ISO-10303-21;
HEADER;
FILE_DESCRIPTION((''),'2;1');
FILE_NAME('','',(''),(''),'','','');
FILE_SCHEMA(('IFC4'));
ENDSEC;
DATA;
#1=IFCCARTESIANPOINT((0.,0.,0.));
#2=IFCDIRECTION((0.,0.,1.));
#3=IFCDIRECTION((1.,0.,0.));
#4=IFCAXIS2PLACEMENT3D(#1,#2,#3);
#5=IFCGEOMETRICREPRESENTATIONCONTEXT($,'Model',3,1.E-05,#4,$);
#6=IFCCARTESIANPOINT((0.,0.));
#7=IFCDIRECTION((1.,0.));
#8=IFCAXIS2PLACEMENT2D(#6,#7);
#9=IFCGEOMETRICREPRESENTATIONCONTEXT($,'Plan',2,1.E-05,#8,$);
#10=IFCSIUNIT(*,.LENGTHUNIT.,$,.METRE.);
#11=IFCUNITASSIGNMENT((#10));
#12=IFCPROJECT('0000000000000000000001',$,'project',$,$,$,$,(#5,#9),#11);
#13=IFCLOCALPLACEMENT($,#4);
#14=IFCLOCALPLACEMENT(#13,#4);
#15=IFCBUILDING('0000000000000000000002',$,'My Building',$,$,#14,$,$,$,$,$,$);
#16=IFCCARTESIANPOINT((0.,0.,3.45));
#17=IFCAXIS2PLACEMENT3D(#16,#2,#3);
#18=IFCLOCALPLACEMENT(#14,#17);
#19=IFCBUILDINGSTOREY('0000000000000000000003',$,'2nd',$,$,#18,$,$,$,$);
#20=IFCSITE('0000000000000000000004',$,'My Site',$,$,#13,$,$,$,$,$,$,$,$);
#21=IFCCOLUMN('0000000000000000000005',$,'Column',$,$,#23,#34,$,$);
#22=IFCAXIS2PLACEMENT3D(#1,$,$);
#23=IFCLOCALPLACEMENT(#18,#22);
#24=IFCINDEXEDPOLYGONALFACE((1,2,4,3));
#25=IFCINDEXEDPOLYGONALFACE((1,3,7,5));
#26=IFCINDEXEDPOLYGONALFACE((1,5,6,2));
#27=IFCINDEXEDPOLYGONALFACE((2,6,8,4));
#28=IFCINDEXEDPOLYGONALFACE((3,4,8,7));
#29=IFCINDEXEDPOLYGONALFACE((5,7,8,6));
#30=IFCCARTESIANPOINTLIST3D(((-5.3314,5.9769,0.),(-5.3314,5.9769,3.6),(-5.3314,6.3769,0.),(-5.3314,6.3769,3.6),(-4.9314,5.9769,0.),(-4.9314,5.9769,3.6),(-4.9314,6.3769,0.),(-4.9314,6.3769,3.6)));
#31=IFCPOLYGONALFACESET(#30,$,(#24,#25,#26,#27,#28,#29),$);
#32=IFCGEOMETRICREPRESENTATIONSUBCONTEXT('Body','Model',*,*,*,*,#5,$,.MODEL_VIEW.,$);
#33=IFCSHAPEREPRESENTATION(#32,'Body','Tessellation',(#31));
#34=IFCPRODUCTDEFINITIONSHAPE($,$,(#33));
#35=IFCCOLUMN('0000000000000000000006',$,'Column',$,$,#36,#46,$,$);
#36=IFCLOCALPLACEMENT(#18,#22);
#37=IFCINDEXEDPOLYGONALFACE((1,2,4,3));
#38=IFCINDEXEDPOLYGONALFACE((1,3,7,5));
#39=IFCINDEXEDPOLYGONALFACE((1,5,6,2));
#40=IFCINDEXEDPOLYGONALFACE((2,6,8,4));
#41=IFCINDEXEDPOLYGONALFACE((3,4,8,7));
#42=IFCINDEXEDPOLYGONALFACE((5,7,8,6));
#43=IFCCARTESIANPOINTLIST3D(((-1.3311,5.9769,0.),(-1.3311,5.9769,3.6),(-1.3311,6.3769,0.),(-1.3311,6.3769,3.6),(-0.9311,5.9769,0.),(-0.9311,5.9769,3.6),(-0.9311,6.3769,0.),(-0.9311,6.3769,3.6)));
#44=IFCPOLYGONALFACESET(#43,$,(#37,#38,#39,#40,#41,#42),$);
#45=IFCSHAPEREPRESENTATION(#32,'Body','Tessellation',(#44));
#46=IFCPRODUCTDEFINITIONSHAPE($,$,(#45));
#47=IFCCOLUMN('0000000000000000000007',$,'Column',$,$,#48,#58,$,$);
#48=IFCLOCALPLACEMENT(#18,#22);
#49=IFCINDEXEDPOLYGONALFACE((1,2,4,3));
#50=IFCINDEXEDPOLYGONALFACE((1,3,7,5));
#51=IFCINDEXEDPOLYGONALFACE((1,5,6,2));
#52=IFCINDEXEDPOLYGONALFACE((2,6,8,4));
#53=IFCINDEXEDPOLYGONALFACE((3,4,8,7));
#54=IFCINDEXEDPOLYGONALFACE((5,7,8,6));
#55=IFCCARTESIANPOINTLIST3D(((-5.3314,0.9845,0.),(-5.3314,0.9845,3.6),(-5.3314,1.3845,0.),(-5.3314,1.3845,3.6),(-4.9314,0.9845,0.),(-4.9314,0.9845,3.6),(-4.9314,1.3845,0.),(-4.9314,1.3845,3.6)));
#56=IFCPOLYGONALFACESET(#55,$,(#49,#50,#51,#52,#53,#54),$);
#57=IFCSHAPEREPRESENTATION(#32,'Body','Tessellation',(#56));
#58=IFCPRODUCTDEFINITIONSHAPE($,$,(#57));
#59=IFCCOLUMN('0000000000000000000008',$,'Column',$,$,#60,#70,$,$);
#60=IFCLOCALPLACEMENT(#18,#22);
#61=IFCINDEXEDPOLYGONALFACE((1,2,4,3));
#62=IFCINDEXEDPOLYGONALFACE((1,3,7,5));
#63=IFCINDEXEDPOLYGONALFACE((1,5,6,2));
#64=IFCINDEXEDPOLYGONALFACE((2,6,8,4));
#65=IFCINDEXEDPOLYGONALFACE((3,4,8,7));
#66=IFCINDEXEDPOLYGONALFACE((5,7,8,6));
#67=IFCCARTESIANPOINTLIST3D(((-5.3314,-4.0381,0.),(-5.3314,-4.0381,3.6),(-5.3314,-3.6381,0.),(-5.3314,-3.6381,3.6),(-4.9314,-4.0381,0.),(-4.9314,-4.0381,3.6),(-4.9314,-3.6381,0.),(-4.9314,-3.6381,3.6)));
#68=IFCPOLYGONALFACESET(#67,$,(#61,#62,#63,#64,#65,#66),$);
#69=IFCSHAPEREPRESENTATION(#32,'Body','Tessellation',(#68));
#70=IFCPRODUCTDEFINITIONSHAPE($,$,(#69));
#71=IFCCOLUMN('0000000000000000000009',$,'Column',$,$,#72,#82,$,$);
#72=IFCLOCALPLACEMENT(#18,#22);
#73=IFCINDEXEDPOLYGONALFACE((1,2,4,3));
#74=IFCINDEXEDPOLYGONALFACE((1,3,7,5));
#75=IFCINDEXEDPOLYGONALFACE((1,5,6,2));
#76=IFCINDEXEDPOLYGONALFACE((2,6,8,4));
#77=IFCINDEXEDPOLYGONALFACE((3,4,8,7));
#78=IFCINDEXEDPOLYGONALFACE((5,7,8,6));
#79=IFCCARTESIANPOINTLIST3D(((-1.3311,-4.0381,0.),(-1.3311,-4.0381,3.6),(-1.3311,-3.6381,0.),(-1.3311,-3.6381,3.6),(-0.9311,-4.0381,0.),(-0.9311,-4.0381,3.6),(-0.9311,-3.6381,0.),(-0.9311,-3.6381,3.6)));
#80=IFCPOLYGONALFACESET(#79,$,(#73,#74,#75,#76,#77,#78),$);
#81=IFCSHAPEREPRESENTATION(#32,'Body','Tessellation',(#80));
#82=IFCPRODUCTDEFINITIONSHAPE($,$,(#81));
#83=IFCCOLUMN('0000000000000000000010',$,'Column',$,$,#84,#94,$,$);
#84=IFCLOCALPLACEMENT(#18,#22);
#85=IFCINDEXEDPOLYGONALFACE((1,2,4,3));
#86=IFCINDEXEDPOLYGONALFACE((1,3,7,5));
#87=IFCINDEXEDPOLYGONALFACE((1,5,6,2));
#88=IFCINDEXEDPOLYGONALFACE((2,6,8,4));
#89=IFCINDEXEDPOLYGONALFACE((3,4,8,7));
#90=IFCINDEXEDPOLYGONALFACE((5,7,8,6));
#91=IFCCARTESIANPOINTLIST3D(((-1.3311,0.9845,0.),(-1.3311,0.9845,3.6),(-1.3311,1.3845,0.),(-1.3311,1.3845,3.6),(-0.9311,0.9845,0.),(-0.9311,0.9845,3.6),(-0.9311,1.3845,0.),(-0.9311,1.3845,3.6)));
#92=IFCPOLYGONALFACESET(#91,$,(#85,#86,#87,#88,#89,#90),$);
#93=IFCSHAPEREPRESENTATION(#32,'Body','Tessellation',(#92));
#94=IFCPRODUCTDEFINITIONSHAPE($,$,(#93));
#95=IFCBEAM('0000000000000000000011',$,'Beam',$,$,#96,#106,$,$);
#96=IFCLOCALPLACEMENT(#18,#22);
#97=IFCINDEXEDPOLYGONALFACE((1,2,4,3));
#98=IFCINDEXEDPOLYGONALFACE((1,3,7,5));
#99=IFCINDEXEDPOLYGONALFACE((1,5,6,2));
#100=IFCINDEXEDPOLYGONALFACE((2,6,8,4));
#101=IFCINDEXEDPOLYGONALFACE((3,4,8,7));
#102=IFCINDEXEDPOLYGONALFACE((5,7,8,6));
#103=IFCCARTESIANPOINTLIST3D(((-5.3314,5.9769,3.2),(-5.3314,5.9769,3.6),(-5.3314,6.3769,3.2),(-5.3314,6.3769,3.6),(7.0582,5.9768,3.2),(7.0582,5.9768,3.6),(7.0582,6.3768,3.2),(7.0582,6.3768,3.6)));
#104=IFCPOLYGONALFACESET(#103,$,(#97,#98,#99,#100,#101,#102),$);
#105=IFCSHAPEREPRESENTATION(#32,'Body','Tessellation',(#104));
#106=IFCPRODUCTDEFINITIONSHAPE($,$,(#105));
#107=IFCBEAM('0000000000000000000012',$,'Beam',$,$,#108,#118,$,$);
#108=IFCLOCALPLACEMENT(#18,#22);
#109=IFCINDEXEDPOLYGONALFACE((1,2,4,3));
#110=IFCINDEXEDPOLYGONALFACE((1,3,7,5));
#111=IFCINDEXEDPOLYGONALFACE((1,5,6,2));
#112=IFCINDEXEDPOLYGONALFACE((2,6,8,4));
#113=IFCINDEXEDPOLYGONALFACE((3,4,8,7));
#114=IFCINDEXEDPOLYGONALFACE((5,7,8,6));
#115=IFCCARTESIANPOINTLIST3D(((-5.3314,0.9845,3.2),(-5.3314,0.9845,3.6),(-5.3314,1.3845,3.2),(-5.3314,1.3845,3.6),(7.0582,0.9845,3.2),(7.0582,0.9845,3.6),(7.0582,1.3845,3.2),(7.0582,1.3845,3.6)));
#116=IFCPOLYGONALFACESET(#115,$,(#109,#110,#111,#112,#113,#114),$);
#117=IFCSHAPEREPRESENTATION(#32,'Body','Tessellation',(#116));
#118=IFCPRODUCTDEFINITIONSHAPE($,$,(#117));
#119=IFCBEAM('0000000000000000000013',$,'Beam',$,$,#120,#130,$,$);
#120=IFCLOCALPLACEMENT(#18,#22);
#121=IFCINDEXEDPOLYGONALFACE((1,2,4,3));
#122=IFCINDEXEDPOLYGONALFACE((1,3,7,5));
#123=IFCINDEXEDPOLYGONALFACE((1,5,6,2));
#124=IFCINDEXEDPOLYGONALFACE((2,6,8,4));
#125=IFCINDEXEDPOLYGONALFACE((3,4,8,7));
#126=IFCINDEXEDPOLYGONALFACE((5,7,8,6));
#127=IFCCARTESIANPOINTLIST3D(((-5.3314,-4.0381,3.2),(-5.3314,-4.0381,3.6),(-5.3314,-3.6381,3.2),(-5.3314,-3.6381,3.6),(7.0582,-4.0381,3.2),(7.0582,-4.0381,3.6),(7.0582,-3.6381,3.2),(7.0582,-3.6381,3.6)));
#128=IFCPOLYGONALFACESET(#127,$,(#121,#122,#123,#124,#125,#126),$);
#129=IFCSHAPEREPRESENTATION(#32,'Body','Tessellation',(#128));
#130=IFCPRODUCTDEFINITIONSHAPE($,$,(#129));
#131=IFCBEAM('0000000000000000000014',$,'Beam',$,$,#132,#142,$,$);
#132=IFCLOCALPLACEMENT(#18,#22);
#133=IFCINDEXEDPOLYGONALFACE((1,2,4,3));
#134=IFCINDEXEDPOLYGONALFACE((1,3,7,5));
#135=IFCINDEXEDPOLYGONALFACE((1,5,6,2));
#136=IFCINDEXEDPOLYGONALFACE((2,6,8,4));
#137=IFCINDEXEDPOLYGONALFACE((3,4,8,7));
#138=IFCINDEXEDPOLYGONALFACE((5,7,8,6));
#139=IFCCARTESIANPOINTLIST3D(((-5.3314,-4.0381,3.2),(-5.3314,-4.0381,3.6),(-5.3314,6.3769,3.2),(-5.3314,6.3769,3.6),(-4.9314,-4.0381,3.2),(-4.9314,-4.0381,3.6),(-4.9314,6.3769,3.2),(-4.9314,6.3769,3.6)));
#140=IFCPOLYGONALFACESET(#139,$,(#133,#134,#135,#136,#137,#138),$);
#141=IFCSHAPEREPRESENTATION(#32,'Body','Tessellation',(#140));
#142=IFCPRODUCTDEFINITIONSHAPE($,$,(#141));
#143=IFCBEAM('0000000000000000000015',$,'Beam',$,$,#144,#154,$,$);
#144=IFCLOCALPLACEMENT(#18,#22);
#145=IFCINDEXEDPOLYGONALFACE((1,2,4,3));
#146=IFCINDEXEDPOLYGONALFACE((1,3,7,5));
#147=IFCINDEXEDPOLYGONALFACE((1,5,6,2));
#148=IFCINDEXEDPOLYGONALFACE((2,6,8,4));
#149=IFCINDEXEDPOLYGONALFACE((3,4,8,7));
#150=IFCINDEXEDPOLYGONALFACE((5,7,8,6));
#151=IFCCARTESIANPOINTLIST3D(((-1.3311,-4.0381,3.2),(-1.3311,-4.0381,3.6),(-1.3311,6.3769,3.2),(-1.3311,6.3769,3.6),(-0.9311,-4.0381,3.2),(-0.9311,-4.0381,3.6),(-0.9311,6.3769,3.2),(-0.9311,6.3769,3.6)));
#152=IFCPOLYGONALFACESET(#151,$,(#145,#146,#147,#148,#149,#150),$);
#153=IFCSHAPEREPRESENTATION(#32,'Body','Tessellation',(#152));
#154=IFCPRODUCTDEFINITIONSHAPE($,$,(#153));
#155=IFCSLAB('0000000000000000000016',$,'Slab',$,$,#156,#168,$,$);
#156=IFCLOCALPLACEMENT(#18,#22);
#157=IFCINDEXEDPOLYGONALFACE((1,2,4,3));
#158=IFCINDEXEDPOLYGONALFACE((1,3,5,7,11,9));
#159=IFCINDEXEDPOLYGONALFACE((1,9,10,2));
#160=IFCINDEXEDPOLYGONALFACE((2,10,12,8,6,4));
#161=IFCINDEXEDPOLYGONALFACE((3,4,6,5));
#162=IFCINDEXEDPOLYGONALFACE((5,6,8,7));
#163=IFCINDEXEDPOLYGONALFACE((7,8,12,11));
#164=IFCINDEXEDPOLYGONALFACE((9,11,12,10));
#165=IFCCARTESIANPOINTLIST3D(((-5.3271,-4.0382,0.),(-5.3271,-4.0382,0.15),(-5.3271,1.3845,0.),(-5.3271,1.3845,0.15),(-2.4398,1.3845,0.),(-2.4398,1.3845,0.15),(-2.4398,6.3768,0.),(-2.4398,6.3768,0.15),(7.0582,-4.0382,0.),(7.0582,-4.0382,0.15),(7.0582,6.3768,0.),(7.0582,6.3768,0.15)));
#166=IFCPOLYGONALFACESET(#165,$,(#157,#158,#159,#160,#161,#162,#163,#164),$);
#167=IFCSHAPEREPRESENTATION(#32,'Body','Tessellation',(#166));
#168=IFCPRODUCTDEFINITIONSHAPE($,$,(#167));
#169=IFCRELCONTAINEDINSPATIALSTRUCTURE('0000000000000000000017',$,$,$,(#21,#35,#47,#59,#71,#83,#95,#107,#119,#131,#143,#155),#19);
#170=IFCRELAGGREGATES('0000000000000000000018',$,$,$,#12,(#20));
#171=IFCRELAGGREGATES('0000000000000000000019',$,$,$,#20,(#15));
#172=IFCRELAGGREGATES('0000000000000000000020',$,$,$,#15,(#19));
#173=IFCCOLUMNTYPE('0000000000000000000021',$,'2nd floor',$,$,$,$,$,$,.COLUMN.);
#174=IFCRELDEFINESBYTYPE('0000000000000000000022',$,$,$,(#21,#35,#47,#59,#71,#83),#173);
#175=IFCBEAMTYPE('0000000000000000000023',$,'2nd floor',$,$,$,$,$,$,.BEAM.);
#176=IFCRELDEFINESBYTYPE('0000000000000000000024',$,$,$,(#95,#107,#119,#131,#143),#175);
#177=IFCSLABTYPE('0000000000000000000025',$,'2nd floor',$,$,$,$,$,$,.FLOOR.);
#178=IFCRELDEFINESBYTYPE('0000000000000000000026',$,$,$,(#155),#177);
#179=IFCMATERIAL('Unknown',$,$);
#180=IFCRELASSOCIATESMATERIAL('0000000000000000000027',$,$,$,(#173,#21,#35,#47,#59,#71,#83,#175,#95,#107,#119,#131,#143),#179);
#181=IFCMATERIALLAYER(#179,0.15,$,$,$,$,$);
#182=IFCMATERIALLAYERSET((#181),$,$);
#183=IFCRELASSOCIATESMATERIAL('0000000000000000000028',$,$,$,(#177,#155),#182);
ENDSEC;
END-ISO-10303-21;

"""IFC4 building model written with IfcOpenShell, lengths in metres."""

from ifc_helpers import new_model, si_unit, frame, origin_with_axes, origin_2d_with_axis, place, context, subcontext, project, spatial, indexed_curve, rectangle, outline, extrude, material, layer, layer_set, layer_usage, material_profile, profile_set, profile_usage, type_object, element, save


model = new_model("IFC4")

# Units and contexts
model_context = context("Model", 3, precision=1e-05, world=origin_with_axes())
plan_context = context("Plan", 2, precision=1e-05, world=origin_2d_with_axis())
body_context_1 = subcontext(model_context, "Body", "Model", "MODEL_VIEW")
ifc_project = project(units=[si_unit("LENGTHUNIT", "METRE")], contexts=[model_context, plan_context])

# Site, building, storey
site_placement = place(None, origin_with_axes())
site = spatial("IfcSite", under=ifc_project, at=site_placement, Name="My Site")
building_placement = place(site_placement, origin_with_axes())
building = spatial("IfcBuilding", under=site, at=building_placement, Name="My Building")
storey_placement = place(building_placement, frame((0.0, 0.0, 3.45), z_axis=(0.0, 0.0, 1.0), x_axis=(1.0, 0.0, 0.0)))
storey = spatial("IfcBuildingStorey", under=building, at=storey_placement, Name="2nd")

# Columns
ifc_material = material(Name="Unknown")
ifc_material_profile_1 = material_profile(ifc_material, rectangle(XDim=0.4, YDim=0.4))
ifc_profile_set_1 = profile_set([ifc_material_profile_1])
ifc_profile_usage_1 = profile_usage(ifc_profile_set_1, cardinal=5)
column_type = type_object("IfcColumnType", Name="2nd floor", PredefinedType="COLUMN", material=ifc_profile_set_1)
column_1_placement = place(storey_placement, frame((-5.1314, 6.1769, 0.0), z_axis=(0.0, 0.0, 1.0), x_axis=(1.0, 0.0, 0.0)))
element("IfcColumn", 1, at=column_1_placement, inside=storey, type_object=column_type, material=ifc_profile_usage_1, Name="Column", context=body_context_1, shape_type="SweptSolid", body=[
    extrude(rectangle(XDim=0.4, YDim=0.4), origin_with_axes(), (0.0, 0.0, 1.0), 3.6),
])
ifc_profile_usage_2 = profile_usage(ifc_profile_set_1, cardinal=5)
column_2_placement = place(storey_placement, frame((-1.1311, 6.1769, 0.0), z_axis=(0.0, 0.0, 1.0), x_axis=(1.0, 0.0, 0.0)))
element("IfcColumn", 2, at=column_2_placement, inside=storey, type_object=column_type, material=ifc_profile_usage_2, Name="Column", context=body_context_1, shape_type="SweptSolid", body=[
    extrude(rectangle(XDim=0.4, YDim=0.4), origin_with_axes(), (0.0, 0.0, 1.0), 3.6),
])
ifc_profile_usage_3 = profile_usage(ifc_profile_set_1, cardinal=5)
column_3_placement = place(storey_placement, frame((-5.1314, 1.1845, 0.0), z_axis=(0.0, 0.0, 1.0), x_axis=(1.0, 0.0, 0.0)))
element("IfcColumn", 3, at=column_3_placement, inside=storey, type_object=column_type, material=ifc_profile_usage_3, Name="Column", context=body_context_1, shape_type="SweptSolid", body=[
    extrude(rectangle(XDim=0.4, YDim=0.4), origin_with_axes(), (0.0, 0.0, 1.0), 3.6),
])
ifc_profile_usage_4 = profile_usage(ifc_profile_set_1, cardinal=5)
column_4_placement = place(storey_placement, frame((-5.1314, -3.8381, 0.0), z_axis=(0.0, 0.0, 1.0), x_axis=(1.0, 0.0, 0.0)))
element("IfcColumn", 4, at=column_4_placement, inside=storey, type_object=column_type, material=ifc_profile_usage_4, Name="Column", context=body_context_1, shape_type="SweptSolid", body=[
    extrude(rectangle(XDim=0.4, YDim=0.4), origin_with_axes(), (0.0, 0.0, 1.0), 3.6),
])
ifc_profile_usage_5 = profile_usage(ifc_profile_set_1, cardinal=5)
column_5_placement = place(storey_placement, frame((-1.1311, -3.8381, 0.0), z_axis=(0.0, 0.0, 1.0), x_axis=(1.0, 0.0, 0.0)))
element("IfcColumn", 5, at=column_5_placement, inside=storey, type_object=column_type, material=ifc_profile_usage_5, Name="Column", context=body_context_1, shape_type="SweptSolid", body=[
    extrude(rectangle(XDim=0.4, YDim=0.4), origin_with_axes(), (0.0, 0.0, 1.0), 3.6),
])
ifc_profile_usage_6 = profile_usage(ifc_profile_set_1, cardinal=5)
column_6_placement = place(storey_placement, frame((-1.1311, 1.1845, 0.0), z_axis=(0.0, 0.0, 1.0), x_axis=(1.0, 0.0, 0.0)))
element("IfcColumn", 6, at=column_6_placement, inside=storey, type_object=column_type, material=ifc_profile_usage_6, Name="Column", context=body_context_1, shape_type="SweptSolid", body=[
    extrude(rectangle(XDim=0.4, YDim=0.4), origin_with_axes(), (0.0, 0.0, 1.0), 3.6),
])

# Beams
ifc_material_profile_2 = material_profile(ifc_material, rectangle(XDim=0.4, YDim=0.4))
ifc_profile_set_2 = profile_set([ifc_material_profile_2])
ifc_profile_usage_7 = profile_usage(ifc_profile_set_2, cardinal=5)
beam_type = type_object("IfcBeamType", Name="2nd floor", PredefinedType="BEAM", material=ifc_profile_set_2)
beam_1_placement = place(storey_placement, frame((-5.3314, 6.1769, 3.4), z_axis=(1.0, -0.000001, 0.000001), x_axis=(0.000001, 1.0, 0.0)))
element("IfcBeam", 7, at=beam_1_placement, inside=storey, type_object=beam_type, material=ifc_profile_usage_7, Name="Beam", context=body_context_1, shape_type="SweptSolid", body=[
    extrude(rectangle(XDim=0.4, YDim=0.4), origin_with_axes(), (0.0, 0.0, 1.0), 12.3896),
])
ifc_profile_usage_8 = profile_usage(ifc_profile_set_2, cardinal=5)
beam_2_placement = place(storey_placement, frame((-5.3314, 1.1845, 3.4), z_axis=(1.0, -0.000001, 0.000001), x_axis=(0.000001, 1.0, 0.0)))
element("IfcBeam", 8, at=beam_2_placement, inside=storey, type_object=beam_type, material=ifc_profile_usage_8, Name="Beam", context=body_context_1, shape_type="SweptSolid", body=[
    extrude(rectangle(XDim=0.4, YDim=0.4), origin_with_axes(), (0.0, 0.0, 1.0), 12.3896),
])
ifc_profile_usage_9 = profile_usage(ifc_profile_set_2, cardinal=5)
beam_3_placement = place(storey_placement, frame((-5.3314, -3.8381, 3.4), z_axis=(1.0, -0.000001, 0.000001), x_axis=(0.000001, 1.0, 0.0)))
element("IfcBeam", 9, at=beam_3_placement, inside=storey, type_object=beam_type, material=ifc_profile_usage_9, Name="Beam", context=body_context_1, shape_type="SweptSolid", body=[
    extrude(rectangle(XDim=0.4, YDim=0.4), origin_with_axes(), (0.0, 0.0, 1.0), 12.3896),
])
ifc_profile_usage_10 = profile_usage(ifc_profile_set_2, cardinal=5)
beam_4_placement = place(storey_placement, frame((-5.1314, 6.3769, 3.4), z_axis=(0.0, -1.0, 0.0), x_axis=(1.0, 0.0, 0.0)))
element("IfcBeam", 10, at=beam_4_placement, inside=storey, type_object=beam_type, material=ifc_profile_usage_10, Name="Beam", context=body_context_1, shape_type="SweptSolid", body=[
    extrude(rectangle(XDim=0.4, YDim=0.4), origin_with_axes(), (0.0, 0.0, 1.0), 10.415),
])
ifc_profile_usage_11 = profile_usage(ifc_profile_set_2, cardinal=5)
beam_5_placement = place(storey_placement, frame((-1.1311, 6.3769, 3.4), z_axis=(0.0, -1.0, 0.0), x_axis=(1.0, 0.0, 0.0)))
element("IfcBeam", 11, at=beam_5_placement, inside=storey, type_object=beam_type, material=ifc_profile_usage_11, Name="Beam", context=body_context_1, shape_type="SweptSolid", body=[
    extrude(rectangle(XDim=0.4, YDim=0.4), origin_with_axes(), (0.0, 0.0, 1.0), 10.415),
])

# Slab
ifc_layer_1 = layer(ifc_material, 0.15)
ifc_layer_set_1 = layer_set([ifc_layer_1])
ifc_layer_usage_1 = layer_usage(ifc_layer_set_1, "AXIS3", "POSITIVE", -0.1)
slab_type = type_object("IfcSlabType", Name="2nd floor", PredefinedType="FLOOR", material=ifc_layer_set_1)
slab_1_placement = place(storey_placement, frame((-5.3271, 1.3845, 0.1), z_axis=(0.0, 0.0, 1.0), x_axis=(1.0, 0.0, 0.0)))
element("IfcSlab", 12, at=slab_1_placement, inside=storey, type_object=slab_type, material=ifc_layer_usage_1, Name="Slab", context=body_context_1, shape_type="SweptSolid", body=[
    extrude(outline(indexed_curve([(0.0, 0.0), (2.8874, 0.0), (2.8874, 4.9922), (12.3854, 4.9922), (12.3854, -5.4228), (0.0, -5.4228), (0.0, 0.0)])), frame((0.0, 0.0, -0.1), z_axis=(0.0, 0.0, 1.0), x_axis=(1.0, 0.0, 0.0)), (0.0, 0.0, 1.0), 0.15),
])

save(model, "model.ifc")
